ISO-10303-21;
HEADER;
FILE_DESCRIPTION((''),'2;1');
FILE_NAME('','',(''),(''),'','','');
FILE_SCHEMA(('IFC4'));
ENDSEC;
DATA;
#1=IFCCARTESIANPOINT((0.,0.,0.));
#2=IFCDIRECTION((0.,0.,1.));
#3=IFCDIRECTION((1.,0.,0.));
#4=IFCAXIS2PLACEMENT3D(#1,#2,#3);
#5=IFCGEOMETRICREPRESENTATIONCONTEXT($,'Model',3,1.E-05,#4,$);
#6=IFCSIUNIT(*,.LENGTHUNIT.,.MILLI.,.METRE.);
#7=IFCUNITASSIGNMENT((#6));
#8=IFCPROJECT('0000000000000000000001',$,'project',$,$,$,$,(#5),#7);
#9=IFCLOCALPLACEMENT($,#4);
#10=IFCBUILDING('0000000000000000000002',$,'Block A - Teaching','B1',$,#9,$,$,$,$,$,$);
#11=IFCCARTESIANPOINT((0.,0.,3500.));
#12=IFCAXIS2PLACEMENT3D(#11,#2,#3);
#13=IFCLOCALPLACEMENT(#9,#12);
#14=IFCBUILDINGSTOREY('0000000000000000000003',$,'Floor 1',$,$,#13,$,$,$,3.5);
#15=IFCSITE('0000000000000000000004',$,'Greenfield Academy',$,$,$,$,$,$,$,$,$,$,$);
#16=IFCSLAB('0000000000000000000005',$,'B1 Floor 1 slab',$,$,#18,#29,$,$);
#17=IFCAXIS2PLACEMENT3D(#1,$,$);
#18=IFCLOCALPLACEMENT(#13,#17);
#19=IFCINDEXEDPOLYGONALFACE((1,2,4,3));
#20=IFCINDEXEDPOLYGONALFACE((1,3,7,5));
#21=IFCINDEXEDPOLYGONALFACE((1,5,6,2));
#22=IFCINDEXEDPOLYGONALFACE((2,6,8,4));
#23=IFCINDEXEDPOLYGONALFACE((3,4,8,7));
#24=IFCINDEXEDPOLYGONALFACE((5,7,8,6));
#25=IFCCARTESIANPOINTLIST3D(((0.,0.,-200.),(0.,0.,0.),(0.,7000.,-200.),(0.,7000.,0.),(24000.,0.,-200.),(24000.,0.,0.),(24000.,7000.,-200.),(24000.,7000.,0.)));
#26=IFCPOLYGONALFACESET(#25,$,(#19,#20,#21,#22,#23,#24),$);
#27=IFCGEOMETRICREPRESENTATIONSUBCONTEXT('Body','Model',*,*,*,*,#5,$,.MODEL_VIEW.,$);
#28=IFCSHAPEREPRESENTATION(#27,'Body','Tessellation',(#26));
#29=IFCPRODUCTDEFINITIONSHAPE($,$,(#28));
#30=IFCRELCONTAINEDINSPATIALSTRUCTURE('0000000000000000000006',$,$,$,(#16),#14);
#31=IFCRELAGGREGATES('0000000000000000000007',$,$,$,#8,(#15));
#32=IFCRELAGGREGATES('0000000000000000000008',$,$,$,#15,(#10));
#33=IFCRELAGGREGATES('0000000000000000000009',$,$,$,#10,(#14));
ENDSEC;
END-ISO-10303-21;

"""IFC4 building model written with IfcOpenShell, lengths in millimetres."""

from ifc_helpers import new_model, si_unit, frame, origin_with_axes, place, context, subcontext, project, spatial, indexed_curve, outline, extrude, element, save


model = new_model("IFC4")

# Units and contexts
model_context = context("Model", 3, precision=1e-05, world=origin_with_axes())
body_context = subcontext(model_context, "Body", "Model", "MODEL_VIEW")
ifc_project = project(units=[si_unit("LENGTHUNIT", "METRE", prefix="MILLI")], contexts=[model_context])

# Site, building, storey
site = spatial("IfcSite", under=ifc_project, Name="Greenfield Academy")
building_placement = place(None, origin_with_axes())
building = spatial("IfcBuilding", under=site, at=building_placement, Name="Block A - Teaching", Description="B1")
storey_placement = place(building_placement, frame((0.0, 0.0, 3500.0), z_axis=(0.0, 0.0, 1.0), x_axis=(1.0, 0.0, 0.0)))
storey = spatial("IfcBuildingStorey", under=building, at=storey_placement, Name="Floor 1", Elevation=3.5)

# Slab
slab_placement = place(storey_placement, frame((0.0, 0.0, -200.0), z_axis=(0.0, 0.0, 1.0), x_axis=(1.0, 0.0, 0.0)))
element("IfcSlab", 1, at=slab_placement, inside=storey, Name="B1 Floor 1 slab", context=body_context, shape_type="SweptSolid", body=[
    extrude(outline(indexed_curve([(0.0, 0.0), (0.0, 7000.0), (24000.0, 7000.0), (24000.0, 0.0), (0.0, 0.0)], self_intersect=False)), origin_with_axes(), (0.0, 0.0, 1.0), 200.0),
])

save(model, "model.ifc")
